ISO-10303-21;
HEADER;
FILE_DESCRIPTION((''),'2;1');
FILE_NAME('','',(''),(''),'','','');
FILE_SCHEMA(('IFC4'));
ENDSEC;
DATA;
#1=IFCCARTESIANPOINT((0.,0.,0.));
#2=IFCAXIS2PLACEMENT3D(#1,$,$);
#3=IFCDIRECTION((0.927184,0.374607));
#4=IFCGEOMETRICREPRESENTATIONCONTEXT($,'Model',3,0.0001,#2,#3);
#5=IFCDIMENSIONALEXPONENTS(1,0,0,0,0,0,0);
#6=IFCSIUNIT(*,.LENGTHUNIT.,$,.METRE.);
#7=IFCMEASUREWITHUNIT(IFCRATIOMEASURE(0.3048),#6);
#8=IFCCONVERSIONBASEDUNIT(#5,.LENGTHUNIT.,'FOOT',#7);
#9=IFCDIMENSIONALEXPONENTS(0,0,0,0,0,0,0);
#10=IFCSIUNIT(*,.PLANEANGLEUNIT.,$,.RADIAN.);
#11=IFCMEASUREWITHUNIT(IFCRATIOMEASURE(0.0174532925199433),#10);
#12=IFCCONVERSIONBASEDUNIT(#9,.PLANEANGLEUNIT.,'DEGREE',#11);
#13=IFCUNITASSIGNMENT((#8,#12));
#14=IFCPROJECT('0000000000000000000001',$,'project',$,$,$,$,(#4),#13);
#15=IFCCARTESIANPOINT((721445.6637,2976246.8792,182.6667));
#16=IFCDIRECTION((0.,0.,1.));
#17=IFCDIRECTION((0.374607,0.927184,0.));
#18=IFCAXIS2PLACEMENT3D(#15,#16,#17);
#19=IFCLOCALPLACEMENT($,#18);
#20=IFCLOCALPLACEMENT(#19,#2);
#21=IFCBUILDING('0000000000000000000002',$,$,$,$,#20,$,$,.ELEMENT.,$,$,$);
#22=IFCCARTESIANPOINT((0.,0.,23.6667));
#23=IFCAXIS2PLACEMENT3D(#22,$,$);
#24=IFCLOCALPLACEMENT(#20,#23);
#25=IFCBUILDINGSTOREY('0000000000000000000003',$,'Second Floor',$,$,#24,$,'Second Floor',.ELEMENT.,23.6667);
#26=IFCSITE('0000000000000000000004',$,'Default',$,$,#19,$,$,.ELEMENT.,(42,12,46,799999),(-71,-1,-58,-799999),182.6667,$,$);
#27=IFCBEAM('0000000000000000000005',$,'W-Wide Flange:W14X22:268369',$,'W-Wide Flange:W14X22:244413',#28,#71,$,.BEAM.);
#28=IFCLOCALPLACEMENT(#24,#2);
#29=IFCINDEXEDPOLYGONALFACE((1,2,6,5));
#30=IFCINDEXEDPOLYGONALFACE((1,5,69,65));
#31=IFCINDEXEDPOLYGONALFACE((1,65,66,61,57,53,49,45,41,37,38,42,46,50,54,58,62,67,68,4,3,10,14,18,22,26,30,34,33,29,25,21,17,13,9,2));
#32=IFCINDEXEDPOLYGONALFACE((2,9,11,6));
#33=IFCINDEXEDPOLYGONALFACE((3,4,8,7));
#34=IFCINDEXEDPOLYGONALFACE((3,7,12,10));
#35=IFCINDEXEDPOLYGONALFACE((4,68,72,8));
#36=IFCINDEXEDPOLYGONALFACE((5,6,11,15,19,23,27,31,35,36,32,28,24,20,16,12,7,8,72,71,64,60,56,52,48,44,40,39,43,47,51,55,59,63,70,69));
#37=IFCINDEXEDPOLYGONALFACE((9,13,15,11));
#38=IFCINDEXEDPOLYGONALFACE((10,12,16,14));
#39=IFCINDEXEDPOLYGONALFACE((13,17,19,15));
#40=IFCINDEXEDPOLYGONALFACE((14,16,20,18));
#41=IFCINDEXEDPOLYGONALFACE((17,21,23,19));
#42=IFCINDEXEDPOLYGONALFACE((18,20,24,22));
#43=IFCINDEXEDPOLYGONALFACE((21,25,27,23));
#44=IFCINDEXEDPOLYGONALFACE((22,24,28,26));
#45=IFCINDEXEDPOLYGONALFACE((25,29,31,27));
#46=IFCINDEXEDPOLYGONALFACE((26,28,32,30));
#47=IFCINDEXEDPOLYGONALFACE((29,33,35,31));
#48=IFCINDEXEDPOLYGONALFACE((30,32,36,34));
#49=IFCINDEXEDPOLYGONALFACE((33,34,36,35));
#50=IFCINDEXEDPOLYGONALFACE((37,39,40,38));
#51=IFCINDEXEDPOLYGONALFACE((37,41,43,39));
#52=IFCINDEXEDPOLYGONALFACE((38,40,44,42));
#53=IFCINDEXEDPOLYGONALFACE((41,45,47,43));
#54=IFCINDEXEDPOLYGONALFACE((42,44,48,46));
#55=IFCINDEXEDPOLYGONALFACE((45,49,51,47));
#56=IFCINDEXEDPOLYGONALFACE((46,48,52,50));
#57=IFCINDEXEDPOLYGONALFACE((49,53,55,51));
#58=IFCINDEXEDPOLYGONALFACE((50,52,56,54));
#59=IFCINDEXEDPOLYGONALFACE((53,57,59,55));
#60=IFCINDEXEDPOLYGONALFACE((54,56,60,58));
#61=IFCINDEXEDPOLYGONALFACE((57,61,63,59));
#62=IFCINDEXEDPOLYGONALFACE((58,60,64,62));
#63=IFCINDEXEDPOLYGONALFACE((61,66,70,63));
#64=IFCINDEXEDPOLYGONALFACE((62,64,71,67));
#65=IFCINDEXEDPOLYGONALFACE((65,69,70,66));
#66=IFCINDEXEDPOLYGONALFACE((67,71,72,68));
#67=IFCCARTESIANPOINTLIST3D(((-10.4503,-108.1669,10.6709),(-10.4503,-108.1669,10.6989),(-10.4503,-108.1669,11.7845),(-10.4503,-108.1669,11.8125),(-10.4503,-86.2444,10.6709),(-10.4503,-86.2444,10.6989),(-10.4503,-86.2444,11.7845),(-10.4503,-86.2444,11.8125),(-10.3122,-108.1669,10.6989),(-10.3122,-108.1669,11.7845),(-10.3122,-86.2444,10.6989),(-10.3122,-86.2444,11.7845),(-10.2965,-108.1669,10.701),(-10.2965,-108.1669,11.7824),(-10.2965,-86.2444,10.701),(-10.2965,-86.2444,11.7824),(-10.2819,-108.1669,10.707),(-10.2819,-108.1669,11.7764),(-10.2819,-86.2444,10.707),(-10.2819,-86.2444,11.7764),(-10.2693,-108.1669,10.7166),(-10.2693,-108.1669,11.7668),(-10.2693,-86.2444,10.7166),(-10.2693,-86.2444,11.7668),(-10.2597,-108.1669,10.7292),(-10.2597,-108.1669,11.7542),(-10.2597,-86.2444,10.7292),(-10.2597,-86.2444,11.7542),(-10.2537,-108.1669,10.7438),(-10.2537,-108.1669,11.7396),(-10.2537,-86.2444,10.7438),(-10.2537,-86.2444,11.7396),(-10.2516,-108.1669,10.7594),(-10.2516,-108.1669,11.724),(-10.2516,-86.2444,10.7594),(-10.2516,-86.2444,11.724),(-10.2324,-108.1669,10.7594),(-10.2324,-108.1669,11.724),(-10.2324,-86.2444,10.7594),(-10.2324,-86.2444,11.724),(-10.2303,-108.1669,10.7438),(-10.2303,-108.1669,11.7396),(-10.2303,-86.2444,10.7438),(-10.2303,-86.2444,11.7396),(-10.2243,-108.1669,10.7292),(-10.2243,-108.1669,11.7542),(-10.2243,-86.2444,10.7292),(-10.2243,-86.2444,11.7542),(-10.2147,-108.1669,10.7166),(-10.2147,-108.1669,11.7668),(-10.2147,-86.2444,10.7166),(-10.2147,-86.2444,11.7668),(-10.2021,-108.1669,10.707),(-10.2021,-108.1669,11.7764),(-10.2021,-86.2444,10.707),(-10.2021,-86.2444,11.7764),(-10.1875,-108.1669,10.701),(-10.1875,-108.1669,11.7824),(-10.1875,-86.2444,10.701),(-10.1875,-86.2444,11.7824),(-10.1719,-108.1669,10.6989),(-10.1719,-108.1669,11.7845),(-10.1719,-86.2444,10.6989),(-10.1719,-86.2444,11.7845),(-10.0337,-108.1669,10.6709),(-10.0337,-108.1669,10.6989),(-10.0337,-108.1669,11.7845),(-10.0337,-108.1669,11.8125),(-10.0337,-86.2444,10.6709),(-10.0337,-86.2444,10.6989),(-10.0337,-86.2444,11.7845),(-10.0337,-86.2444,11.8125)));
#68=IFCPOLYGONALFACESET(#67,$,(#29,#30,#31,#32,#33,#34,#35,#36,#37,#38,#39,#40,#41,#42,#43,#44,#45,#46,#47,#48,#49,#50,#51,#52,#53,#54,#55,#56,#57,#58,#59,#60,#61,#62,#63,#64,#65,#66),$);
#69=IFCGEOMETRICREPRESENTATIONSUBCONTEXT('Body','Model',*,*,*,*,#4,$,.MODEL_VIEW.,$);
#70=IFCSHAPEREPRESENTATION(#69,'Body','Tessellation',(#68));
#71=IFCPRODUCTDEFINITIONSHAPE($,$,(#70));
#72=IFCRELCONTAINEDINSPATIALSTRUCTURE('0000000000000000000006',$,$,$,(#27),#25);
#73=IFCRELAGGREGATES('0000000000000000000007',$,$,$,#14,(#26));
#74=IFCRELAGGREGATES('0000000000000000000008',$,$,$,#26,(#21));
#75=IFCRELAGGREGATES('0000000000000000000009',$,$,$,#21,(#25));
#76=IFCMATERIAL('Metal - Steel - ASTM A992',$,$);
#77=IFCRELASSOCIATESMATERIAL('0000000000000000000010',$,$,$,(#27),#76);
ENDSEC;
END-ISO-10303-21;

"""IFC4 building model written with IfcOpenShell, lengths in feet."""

from ifc_helpers import new_model, entity, si_unit, converted_unit, direction, frame, frame_2d, origin, place, context, subcontext, project, spatial, i_section, extrude, material, element, save


model = new_model("IFC4")

# Units and contexts
model_context = context("Model", 3, precision=0.0001, world=origin(), true_north=direction((0.927184, 0.374607)))
body_context = subcontext(model_context, "Body", "Model", "MODEL_VIEW")
ifc_project = project(units=[converted_unit("LENGTHUNIT", "FOOT", entity("IfcRatioMeasure", 0.3048), si_unit("LENGTHUNIT", "METRE"), dimensions=[1, 0, 0, 0, 0, 0, 0]), converted_unit("PLANEANGLEUNIT", "DEGREE", entity("IfcRatioMeasure", 0.0174532925199433), si_unit("PLANEANGLEUNIT", "RADIAN"), dimensions=[0, 0, 0, 0, 0, 0, 0])], contexts=[model_context])

# Site, building, storey
site_placement = place(None, frame((721445.6637, 2976246.8792, 182.6667), z_axis=(0.0, 0.0, 1.0), x_axis=(0.374607, 0.927184, 0.0)))
site = spatial("IfcSite", under=ifc_project, at=site_placement, Name="Default", CompositionType="ELEMENT", RefLatitude=(42, 12, 46, 799999), RefLongitude=(-71, -1, -58, -799999), RefElevation=182.6667)
building_placement = place(site_placement, origin())
building = spatial("IfcBuilding", under=site, at=building_placement, CompositionType="ELEMENT")
storey_placement = place(building_placement, frame((0.0, 0.0, 23.6667)))
storey = spatial("IfcBuildingStorey", under=building, at=storey_placement, Name="Second Floor", LongName="Second Floor", CompositionType="ELEMENT", Elevation=23.6667)

# Shared definitions
ifc_material_1 = material(Name="Metal - Steel - ASTM A992")

# Beam
beam_1_placement = place(storey_placement, frame((-10.242, -85.8544, 11.8125), z_axis=(0.0, 0.0, 1.0), x_axis=(0.0, -1.0, 0.0)))
element("IfcBeam", 1, at=beam_1_placement, inside=storey, material=ifc_material_1, Name="W-Wide Flange:W14X22:268369", ObjectType="W-Wide Flange:W14X22:244413", PredefinedType="BEAM", context=body_context, shape_type="SweptSolid", body=[
    extrude(i_section(OverallWidth=0.4167, OverallDepth=1.1416, WebThickness=0.0192, FlangeThickness=0.028, FilletRadius=0.0605, at=frame_2d((0.0, 0.0), x_axis=(0.0, 1.0))), frame((0.39, 0.0, -0.5708), z_axis=(1.0, 0.0, 0.0), x_axis=(0.0, 0.0, -1.0)), (0.0, 0.0, 1.0), 21.9225),
])

save(model, "model.ifc")
